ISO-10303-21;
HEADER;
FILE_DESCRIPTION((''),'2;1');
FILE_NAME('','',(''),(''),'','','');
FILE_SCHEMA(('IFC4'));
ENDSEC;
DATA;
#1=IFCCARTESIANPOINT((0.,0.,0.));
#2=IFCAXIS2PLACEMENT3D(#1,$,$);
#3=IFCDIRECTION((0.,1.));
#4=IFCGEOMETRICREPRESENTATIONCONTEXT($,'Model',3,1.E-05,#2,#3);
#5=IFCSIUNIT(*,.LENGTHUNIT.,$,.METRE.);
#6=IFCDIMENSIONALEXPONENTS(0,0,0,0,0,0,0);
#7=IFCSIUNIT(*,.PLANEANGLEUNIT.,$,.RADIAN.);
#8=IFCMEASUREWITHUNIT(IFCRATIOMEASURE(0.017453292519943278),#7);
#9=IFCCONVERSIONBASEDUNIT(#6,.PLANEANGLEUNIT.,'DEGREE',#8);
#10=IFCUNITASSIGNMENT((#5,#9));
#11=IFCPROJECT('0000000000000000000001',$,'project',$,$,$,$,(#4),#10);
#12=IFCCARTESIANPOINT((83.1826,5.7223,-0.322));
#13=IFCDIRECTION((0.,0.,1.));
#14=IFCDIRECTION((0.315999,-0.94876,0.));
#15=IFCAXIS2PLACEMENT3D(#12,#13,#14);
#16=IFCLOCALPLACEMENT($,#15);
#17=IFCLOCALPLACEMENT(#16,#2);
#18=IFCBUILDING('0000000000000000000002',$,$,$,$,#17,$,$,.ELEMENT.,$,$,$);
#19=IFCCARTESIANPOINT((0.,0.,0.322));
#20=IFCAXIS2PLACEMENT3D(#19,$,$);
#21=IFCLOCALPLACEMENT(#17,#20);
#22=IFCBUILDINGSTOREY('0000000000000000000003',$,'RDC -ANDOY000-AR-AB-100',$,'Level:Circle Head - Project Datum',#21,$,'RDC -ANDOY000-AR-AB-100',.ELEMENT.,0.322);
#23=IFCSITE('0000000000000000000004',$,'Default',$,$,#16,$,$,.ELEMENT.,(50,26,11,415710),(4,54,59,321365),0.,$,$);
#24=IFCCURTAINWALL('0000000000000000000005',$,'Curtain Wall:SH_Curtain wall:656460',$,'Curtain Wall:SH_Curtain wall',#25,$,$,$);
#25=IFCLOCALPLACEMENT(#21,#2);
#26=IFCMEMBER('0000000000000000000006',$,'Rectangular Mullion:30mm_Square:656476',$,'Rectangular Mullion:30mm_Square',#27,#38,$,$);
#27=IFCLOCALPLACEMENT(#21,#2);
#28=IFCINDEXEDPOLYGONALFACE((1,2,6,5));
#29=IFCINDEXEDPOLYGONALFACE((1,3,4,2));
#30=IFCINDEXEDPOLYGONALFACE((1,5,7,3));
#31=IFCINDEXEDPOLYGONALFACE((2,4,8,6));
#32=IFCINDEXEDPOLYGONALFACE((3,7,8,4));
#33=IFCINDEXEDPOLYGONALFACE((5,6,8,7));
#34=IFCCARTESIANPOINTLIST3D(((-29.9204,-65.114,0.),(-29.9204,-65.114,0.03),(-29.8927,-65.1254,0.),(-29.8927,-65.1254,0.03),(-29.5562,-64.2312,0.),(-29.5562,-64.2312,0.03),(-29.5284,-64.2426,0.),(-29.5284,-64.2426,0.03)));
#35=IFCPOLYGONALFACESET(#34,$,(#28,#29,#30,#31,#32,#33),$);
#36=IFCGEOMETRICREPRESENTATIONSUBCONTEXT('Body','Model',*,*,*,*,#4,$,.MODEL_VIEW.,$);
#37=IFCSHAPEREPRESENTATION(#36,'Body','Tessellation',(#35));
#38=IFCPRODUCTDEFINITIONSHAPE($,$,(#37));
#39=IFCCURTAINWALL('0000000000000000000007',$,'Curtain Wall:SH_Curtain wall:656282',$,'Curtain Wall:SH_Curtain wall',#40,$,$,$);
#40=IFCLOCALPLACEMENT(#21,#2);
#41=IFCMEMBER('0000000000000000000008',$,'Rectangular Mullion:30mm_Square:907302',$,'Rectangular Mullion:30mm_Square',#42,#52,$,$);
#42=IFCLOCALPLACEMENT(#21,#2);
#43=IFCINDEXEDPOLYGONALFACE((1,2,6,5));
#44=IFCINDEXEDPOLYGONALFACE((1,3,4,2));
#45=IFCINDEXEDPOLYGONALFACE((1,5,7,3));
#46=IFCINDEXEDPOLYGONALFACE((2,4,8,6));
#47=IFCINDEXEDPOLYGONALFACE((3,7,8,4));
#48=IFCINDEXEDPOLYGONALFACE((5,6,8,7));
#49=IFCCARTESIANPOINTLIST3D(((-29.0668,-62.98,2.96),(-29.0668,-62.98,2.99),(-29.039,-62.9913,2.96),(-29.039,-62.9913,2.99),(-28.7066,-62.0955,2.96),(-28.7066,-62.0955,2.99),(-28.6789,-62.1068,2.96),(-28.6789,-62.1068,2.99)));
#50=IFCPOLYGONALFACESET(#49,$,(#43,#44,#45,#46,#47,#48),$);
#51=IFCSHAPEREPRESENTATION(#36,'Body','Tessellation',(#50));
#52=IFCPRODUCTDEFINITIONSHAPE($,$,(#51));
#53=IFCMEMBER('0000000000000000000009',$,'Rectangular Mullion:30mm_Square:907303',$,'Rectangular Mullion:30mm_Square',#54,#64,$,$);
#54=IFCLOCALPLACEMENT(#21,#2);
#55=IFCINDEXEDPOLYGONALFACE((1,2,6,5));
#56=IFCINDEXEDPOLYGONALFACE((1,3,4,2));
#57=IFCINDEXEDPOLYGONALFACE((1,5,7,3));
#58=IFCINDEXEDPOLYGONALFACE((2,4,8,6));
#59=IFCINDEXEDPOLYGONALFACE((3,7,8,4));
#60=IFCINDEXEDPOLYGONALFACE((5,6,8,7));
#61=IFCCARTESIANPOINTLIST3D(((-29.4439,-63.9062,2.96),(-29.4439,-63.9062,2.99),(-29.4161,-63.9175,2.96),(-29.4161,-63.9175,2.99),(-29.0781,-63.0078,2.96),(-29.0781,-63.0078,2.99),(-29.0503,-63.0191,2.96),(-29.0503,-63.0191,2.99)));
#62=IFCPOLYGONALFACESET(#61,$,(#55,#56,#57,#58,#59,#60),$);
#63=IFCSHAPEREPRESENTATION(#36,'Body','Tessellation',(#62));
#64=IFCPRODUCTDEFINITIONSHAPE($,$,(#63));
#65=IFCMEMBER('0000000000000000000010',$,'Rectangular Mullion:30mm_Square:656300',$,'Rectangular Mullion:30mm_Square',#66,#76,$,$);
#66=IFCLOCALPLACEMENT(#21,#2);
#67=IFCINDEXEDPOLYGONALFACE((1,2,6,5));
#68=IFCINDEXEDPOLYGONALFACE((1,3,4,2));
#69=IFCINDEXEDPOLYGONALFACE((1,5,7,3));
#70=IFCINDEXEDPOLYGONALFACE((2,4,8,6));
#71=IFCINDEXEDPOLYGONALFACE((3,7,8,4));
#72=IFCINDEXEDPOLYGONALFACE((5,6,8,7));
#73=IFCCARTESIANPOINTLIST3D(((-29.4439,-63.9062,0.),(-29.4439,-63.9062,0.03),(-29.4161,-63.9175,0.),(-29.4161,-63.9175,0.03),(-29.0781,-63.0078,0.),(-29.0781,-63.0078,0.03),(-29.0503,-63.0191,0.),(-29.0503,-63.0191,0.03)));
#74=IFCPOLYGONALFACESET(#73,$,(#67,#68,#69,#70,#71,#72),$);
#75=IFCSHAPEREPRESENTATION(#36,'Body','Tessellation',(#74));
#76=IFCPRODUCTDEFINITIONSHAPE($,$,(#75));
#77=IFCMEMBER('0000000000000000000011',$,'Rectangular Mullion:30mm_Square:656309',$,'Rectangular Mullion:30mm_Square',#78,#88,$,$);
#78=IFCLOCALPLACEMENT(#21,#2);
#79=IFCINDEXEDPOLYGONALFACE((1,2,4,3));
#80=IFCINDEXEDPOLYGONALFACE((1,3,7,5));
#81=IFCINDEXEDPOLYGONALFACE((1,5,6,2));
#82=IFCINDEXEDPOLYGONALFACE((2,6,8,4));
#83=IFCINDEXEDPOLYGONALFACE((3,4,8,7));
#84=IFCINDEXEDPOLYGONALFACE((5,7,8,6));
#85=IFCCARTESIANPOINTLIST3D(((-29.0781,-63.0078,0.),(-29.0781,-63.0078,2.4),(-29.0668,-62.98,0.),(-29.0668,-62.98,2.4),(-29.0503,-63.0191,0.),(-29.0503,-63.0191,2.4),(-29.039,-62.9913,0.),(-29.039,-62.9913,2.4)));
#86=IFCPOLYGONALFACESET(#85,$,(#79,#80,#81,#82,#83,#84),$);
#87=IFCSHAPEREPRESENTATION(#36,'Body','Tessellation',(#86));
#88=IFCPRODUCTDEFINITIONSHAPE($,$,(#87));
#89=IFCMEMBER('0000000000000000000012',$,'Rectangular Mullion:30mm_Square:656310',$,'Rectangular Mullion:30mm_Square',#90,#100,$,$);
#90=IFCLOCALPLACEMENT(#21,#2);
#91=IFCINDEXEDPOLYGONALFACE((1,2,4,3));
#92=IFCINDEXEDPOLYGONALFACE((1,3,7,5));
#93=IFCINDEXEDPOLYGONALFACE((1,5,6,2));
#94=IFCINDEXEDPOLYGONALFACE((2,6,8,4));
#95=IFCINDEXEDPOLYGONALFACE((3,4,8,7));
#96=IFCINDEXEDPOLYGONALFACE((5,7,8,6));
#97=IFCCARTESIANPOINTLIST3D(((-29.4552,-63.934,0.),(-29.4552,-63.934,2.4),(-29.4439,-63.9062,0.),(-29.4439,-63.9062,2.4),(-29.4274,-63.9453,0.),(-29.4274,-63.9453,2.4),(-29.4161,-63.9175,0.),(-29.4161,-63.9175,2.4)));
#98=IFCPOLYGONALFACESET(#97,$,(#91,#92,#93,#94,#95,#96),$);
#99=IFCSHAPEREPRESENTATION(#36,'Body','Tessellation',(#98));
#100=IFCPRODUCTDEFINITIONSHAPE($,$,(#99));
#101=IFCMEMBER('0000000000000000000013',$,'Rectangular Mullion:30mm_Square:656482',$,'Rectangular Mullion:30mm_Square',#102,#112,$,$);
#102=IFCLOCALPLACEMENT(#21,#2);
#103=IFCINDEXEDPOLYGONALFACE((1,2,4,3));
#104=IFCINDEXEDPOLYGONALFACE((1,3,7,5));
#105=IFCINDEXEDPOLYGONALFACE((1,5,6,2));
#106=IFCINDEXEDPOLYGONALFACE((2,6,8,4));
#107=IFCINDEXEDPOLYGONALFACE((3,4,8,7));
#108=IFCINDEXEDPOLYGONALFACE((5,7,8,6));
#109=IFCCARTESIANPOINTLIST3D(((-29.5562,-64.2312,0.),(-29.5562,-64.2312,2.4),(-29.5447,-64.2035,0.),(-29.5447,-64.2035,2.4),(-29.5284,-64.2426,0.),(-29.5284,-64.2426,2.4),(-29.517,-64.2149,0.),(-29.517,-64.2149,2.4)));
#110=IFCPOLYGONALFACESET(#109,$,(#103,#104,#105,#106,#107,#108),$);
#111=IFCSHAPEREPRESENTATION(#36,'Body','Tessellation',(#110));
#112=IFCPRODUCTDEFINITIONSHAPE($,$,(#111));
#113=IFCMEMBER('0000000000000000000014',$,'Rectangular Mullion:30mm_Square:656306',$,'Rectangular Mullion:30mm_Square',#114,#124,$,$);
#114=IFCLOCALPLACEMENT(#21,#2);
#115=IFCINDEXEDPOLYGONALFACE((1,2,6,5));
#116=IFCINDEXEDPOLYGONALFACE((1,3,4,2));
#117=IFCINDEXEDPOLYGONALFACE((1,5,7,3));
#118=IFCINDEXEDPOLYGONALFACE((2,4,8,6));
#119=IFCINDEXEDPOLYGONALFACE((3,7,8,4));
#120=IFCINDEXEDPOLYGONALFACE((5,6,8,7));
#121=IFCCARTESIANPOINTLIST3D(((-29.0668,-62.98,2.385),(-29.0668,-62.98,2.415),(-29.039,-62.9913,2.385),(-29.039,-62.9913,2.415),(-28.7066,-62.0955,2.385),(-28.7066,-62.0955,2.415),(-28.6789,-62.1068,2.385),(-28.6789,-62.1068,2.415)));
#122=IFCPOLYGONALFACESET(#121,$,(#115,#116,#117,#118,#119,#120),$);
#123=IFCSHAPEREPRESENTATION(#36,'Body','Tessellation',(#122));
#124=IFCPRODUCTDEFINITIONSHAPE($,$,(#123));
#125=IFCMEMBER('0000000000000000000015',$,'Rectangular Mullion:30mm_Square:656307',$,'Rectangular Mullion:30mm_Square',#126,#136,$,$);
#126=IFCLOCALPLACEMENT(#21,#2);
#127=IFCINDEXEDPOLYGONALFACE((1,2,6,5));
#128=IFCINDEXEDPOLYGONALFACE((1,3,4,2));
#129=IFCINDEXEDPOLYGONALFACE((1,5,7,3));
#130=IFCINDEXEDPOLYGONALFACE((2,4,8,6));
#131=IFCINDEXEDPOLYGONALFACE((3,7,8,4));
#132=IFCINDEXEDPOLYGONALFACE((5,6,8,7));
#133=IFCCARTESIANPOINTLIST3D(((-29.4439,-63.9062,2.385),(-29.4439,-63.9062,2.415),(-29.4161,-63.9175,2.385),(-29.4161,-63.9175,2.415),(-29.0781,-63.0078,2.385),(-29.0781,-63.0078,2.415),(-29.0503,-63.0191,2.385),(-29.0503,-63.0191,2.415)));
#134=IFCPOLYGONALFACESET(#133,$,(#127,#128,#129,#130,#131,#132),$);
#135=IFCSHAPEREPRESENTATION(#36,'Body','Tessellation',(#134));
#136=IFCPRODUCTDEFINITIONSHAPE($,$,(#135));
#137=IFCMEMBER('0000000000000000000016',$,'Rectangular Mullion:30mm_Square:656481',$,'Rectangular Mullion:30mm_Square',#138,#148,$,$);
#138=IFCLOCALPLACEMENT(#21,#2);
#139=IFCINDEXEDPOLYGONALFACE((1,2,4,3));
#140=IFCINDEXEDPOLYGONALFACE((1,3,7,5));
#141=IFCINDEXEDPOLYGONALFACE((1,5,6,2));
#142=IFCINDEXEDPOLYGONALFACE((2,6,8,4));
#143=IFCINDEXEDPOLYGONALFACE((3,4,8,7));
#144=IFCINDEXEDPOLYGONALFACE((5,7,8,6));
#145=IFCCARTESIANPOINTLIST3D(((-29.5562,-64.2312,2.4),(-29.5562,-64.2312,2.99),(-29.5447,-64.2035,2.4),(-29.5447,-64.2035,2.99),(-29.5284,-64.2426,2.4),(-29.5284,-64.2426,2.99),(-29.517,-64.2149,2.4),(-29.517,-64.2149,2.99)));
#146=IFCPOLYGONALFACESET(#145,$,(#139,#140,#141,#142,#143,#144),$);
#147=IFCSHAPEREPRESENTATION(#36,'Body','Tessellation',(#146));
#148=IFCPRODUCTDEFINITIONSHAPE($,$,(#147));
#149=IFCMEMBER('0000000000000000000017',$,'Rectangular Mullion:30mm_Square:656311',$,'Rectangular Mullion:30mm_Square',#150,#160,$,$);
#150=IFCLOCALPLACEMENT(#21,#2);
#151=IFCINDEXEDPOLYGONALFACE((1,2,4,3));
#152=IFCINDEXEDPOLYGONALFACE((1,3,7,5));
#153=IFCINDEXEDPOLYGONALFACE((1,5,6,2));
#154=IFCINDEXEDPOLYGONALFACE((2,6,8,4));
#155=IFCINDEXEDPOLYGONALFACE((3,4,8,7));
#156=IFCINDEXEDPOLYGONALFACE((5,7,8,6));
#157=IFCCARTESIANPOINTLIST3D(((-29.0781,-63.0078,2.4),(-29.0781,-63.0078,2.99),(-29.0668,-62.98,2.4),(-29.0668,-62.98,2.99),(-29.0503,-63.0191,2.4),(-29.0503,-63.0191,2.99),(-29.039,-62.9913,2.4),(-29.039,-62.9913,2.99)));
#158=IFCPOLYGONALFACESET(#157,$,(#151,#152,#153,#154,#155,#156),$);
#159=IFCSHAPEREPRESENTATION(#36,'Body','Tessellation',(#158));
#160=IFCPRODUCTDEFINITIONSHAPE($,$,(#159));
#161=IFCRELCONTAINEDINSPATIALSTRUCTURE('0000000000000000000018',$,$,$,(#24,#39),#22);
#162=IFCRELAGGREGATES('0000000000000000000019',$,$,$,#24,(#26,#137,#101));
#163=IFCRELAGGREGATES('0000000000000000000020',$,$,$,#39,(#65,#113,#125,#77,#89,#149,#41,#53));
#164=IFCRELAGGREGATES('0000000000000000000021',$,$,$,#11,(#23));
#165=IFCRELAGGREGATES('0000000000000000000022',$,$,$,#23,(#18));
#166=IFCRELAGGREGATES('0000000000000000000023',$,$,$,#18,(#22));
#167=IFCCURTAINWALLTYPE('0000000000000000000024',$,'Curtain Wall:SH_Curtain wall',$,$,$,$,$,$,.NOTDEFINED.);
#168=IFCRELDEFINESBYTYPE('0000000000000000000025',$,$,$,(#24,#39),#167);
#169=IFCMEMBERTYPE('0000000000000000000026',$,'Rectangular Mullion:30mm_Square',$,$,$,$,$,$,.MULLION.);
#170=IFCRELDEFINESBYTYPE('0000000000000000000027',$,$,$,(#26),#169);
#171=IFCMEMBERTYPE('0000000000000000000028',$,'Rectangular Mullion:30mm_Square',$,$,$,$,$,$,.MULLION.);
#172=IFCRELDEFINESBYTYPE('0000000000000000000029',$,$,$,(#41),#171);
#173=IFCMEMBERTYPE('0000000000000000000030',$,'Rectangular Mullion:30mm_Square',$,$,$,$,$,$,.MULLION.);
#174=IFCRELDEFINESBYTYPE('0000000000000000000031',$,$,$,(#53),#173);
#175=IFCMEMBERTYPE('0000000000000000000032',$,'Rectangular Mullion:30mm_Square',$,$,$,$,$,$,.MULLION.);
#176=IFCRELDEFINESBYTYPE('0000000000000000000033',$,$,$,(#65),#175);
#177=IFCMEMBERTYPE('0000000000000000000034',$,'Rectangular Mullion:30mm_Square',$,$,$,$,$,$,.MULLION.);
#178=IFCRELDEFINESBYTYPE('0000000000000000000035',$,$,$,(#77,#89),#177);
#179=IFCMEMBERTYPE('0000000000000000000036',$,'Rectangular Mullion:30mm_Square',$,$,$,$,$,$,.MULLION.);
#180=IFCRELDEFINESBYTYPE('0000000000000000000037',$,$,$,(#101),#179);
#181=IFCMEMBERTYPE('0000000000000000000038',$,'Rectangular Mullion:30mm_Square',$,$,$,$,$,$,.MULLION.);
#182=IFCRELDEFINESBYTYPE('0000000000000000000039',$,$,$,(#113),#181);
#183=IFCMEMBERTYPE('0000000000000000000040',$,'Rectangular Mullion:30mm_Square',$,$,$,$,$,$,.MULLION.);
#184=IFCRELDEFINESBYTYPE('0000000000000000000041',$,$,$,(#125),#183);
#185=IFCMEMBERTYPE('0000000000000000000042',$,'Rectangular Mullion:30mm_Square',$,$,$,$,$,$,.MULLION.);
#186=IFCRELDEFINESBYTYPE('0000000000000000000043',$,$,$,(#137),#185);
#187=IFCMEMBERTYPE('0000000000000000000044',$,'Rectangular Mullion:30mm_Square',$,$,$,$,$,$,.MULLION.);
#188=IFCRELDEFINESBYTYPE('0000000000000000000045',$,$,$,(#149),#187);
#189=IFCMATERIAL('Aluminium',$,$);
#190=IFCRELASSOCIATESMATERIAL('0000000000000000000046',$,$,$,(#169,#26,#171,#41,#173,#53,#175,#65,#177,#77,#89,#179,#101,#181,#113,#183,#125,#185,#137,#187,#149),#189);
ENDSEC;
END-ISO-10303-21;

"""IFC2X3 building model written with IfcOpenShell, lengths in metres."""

from ifc_helpers import new_model, entity, si_unit, converted_unit, direction, frame, origin, origin_2d_with_axis, place, context, subcontext, project, spatial, rectangle, extrude, source, transform, mapped, material, type_object, type_shapes, element, aggregate, save


model = new_model("IFC2X3")

# Units and contexts
model_context = context("Model", 3, precision=1e-05, world=origin(), true_north=direction((0.0, 1.0)))
body_context = subcontext(model_context, "Body", "Model", "MODEL_VIEW")
ifc_project = project(units=[si_unit("LENGTHUNIT", "METRE"), converted_unit("PLANEANGLEUNIT", "DEGREE", entity("IfcRatioMeasure", 0.017453292519943278), si_unit("PLANEANGLEUNIT", "RADIAN"), dimensions=[0, 0, 0, 0, 0, 0, 0])], contexts=[model_context])

# Site, building, storey
site_placement = place(None, frame((83.1826, 5.7223, -0.322), z_axis=(0.0, 0.0, 1.0), x_axis=(0.315999, -0.94876, 0.0)))
site = spatial("IfcSite", under=ifc_project, at=site_placement, Name="Default", CompositionType="ELEMENT", RefLatitude=(50, 26, 11, 415710), RefLongitude=(4, 54, 59, 321365), RefElevation=0.0)
building_placement = place(site_placement, origin())
building = spatial("IfcBuilding", under=site, at=building_placement, CompositionType="ELEMENT")
storey_placement = place(building_placement, frame((0.0, 0.0, 0.322)))
storey = spatial("IfcBuildingStorey", under=building, at=storey_placement, Name="RDC -ANDOY000-AR-AB-100", ObjectType="Level:Circle Head - Project Datum", LongName="RDC -ANDOY000-AR-AB-100", CompositionType="ELEMENT", Elevation=0.322)

# Curtain wall, member
curtain_wall_type = type_object("IfcCurtainWallType", Name="Curtain Wall:SH_Curtain wall", PredefinedType="NOTDEFINED")
curtain_wall_1_placement = place(storey_placement, frame((0.0, 0.0, -0.322)))
curtain_wall_1 = element("IfcCurtainWall", 1, at=curtain_wall_1_placement, inside=storey, type_object=curtain_wall_type, Name="Curtain Wall:SH_Curtain wall:656460", ObjectType="Curtain Wall:SH_Curtain wall")
ifc_material_1 = material(Name="Aluminium")
member_type_1 = type_object("IfcMemberType", Name="Rectangular Mullion:30mm_Square", PredefinedType="MULLION", material=ifc_material_1)
shared_shape_1 = source(origin(), body_context, "Body", "SweptSolid", [
    extrude(rectangle(XDim=0.03, YDim=0.03, at=origin_2d_with_axis()), frame((-0.015, 0.0, -0.955), z_axis=(0.0, 0.0, 1.0), x_axis=(0.0, -1.0, 0.0)), (0.0, 0.0, 1.0), 0.955),
])
type_shapes(member_type_1, [shared_shape_1])
member_1_placement = place(curtain_wall_1_placement, frame((-29.5423, -64.2369, 0.322), z_axis=(0.381413, 0.924405, 0.0), x_axis=(0.0, 0.0, -1.0)))
member_1 = element("IfcMember", 2, at=member_1_placement, type_object=member_type_1, material=ifc_material_1, Name="Rectangular Mullion:30mm_Square:656476", ObjectType="Rectangular Mullion:30mm_Square", context=body_context, shape_type="MappedRepresentation", body=[
    mapped(shared_shape_1, transform((0.0, 0.0, 0.0), scale=1.0)),
])

# Curtain wall, members
curtain_wall_2_placement = place(storey_placement, frame((0.0, 0.0, -0.322)))
curtain_wall_2 = element("IfcCurtainWall", 3, at=curtain_wall_2_placement, inside=storey, type_object=curtain_wall_type, Name="Curtain Wall:SH_Curtain wall:656282", ObjectType="Curtain Wall:SH_Curtain wall")
member_type_2 = type_object("IfcMemberType", Name="Rectangular Mullion:30mm_Square", PredefinedType="MULLION", material=ifc_material_1)
shared_shape_2 = source(origin(), body_context, "Body", "SweptSolid", [
    extrude(rectangle(XDim=0.03, YDim=0.03, at=origin_2d_with_axis()), frame((-0.015, 0.0, -0.955), z_axis=(0.0, 0.0, 1.0), x_axis=(0.0, -1.0, 0.0)), (0.0, 0.0, 1.0), 0.955),
])
type_shapes(member_type_2, [shared_shape_2])
member_2_placement = place(curtain_wall_2_placement, frame((-29.0529, -62.9857, 3.312), z_axis=(-0.377092, -0.926176, 0.0), x_axis=(0.0, 0.0, 1.0)))
member_2 = element("IfcMember", 4, at=member_2_placement, type_object=member_type_2, material=ifc_material_1, Name="Rectangular Mullion:30mm_Square:907302", ObjectType="Rectangular Mullion:30mm_Square", context=body_context, shape_type="MappedRepresentation", body=[
    mapped(shared_shape_2, transform((0.0, 0.0, 0.0), scale=1.0)),
])
member_type_3 = type_object("IfcMemberType", Name="Rectangular Mullion:30mm_Square", PredefinedType="MULLION", material=ifc_material_1)
shared_shape_3 = source(origin(), body_context, "Body", "SweptSolid", [
    extrude(rectangle(XDim=0.03, YDim=0.03, at=origin_2d_with_axis()), frame((-0.015, 0.0, -0.97), z_axis=(0.0, 0.0, 1.0), x_axis=(0.0, -1.0, 0.0)), (0.0, 0.0, 1.0), 0.97),
])
type_shapes(member_type_3, [shared_shape_3])
member_3_placement = place(curtain_wall_2_placement, frame((-29.43, -63.9119, 3.312), z_axis=(-0.377092, -0.926176, 0.0), x_axis=(0.0, 0.0, 1.0)))
member_3 = element("IfcMember", 5, at=member_3_placement, type_object=member_type_3, material=ifc_material_1, Name="Rectangular Mullion:30mm_Square:907303", ObjectType="Rectangular Mullion:30mm_Square", context=body_context, shape_type="MappedRepresentation", body=[
    mapped(shared_shape_3, transform((0.0, 0.0, 0.0), scale=1.0)),
])
member_type_4 = type_object("IfcMemberType", Name="Rectangular Mullion:30mm_Square", PredefinedType="MULLION", material=ifc_material_1)
shared_shape_4 = source(origin(), body_context, "Body", "SweptSolid", [
    extrude(rectangle(XDim=0.03, YDim=0.03, at=origin_2d_with_axis()), frame((-0.015, 0.0, -0.97), z_axis=(0.0, 0.0, 1.0), x_axis=(0.0, -1.0, 0.0)), (0.0, 0.0, 1.0), 0.97),
])
type_shapes(member_type_4, [shared_shape_4])
member_4_placement = place(curtain_wall_2_placement, frame((-29.0642, -63.0135, 0.322), z_axis=(0.377092, 0.926176, 0.0), x_axis=(0.0, 0.0, -1.0)))
member_4 = element("IfcMember", 6, at=member_4_placement, type_object=member_type_4, material=ifc_material_1, Name="Rectangular Mullion:30mm_Square:656300", ObjectType="Rectangular Mullion:30mm_Square", context=body_context, shape_type="MappedRepresentation", body=[
    mapped(shared_shape_4, transform((0.0, 0.0, 0.0), scale=1.0)),
])
member_type_5 = type_object("IfcMemberType", Name="Rectangular Mullion:30mm_Square", PredefinedType="MULLION", material=ifc_material_1)
shared_shape_5 = source(origin(), body_context, "Body", "SweptSolid", [
    extrude(rectangle(XDim=0.03, YDim=0.03, at=origin_2d_with_axis()), frame((0.0, 0.0, -2.4), z_axis=(0.0, 0.0, 1.0), x_axis=(0.0, -1.0, 0.0)), (0.0, 0.0, 1.0), 2.4),
])
type_shapes(member_type_5, [shared_shape_5])
member_5_placement = place(curtain_wall_2_placement, frame((-29.0585, -62.9996, 0.322), z_axis=(0.0, 0.0, -1.0), x_axis=(-0.377092, -0.926176, 0.0)))
member_5 = element("IfcMember", 7, at=member_5_placement, type_object=member_type_5, material=ifc_material_1, Name="Rectangular Mullion:30mm_Square:656309", ObjectType="Rectangular Mullion:30mm_Square", context=body_context, shape_type="MappedRepresentation", body=[
    mapped(shared_shape_5, transform((0.0, 0.0, 0.0), scale=1.0)),
])
member_6_placement = place(curtain_wall_2_placement, frame((-29.4356, -63.9258, 0.322), z_axis=(0.0, 0.0, -1.0), x_axis=(-0.377092, -0.926176, 0.0)))
member_6 = element("IfcMember", 8, at=member_6_placement, type_object=member_type_5, material=ifc_material_1, Name="Rectangular Mullion:30mm_Square:656310", ObjectType="Rectangular Mullion:30mm_Square", context=body_context, shape_type="MappedRepresentation", body=[
    mapped(shared_shape_5, transform((0.0, 0.0, 0.0), scale=1.0)),
])

# Members
member_type_6 = type_object("IfcMemberType", Name="Rectangular Mullion:30mm_Square", PredefinedType="MULLION", material=ifc_material_1)
shared_shape_6 = source(origin(), body_context, "Body", "SweptSolid", [
    extrude(rectangle(XDim=0.03, YDim=0.03, at=origin_2d_with_axis()), frame((-0.015, 0.0, -2.4), z_axis=(0.0, 0.0, 1.0), x_axis=(0.0, -1.0, 0.0)), (0.0, 0.0, 1.0), 2.4),
])
type_shapes(member_type_6, [shared_shape_6])
member_7_placement = place(curtain_wall_1_placement, frame((-29.5309, -64.2092, 2.722), z_axis=(0.0, 0.0, 1.0), x_axis=(0.381413, 0.924405, 0.0)))
member_7 = element("IfcMember", 9, at=member_7_placement, type_object=member_type_6, material=ifc_material_1, Name="Rectangular Mullion:30mm_Square:656482", ObjectType="Rectangular Mullion:30mm_Square", context=body_context, shape_type="MappedRepresentation", body=[
    mapped(shared_shape_6, transform((0.0, 0.0, 0.0), scale=1.0)),
])
member_type_7 = type_object("IfcMemberType", Name="Rectangular Mullion:30mm_Square", PredefinedType="MULLION", material=ifc_material_1)
shared_shape_7 = source(origin(), body_context, "Body", "SweptSolid", [
    extrude(rectangle(XDim=0.03, YDim=0.03, at=origin_2d_with_axis()), frame((0.0, 0.0, -0.955), z_axis=(0.0, 0.0, 1.0), x_axis=(0.0, -1.0, 0.0)), (0.0, 0.0, 1.0), 0.955),
])
type_shapes(member_type_7, [shared_shape_7])
member_8_placement = place(curtain_wall_2_placement, frame((-29.0529, -62.9857, 2.722), z_axis=(-0.377092, -0.926176, 0.0), x_axis=(0.0, 0.0, 1.0)))
member_8 = element("IfcMember", 10, at=member_8_placement, type_object=member_type_7, material=ifc_material_1, Name="Rectangular Mullion:30mm_Square:656306", ObjectType="Rectangular Mullion:30mm_Square", context=body_context, shape_type="MappedRepresentation", body=[
    mapped(shared_shape_7, transform((0.0, 0.0, 0.0), scale=1.0)),
])
member_type_8 = type_object("IfcMemberType", Name="Rectangular Mullion:30mm_Square", PredefinedType="MULLION", material=ifc_material_1)
shared_shape_8 = source(origin(), body_context, "Body", "SweptSolid", [
    extrude(rectangle(XDim=0.03, YDim=0.03, at=origin_2d_with_axis()), frame((0.0, 0.0, -0.97), z_axis=(0.0, 0.0, 1.0), x_axis=(0.0, -1.0, 0.0)), (0.0, 0.0, 1.0), 0.97),
])
type_shapes(member_type_8, [shared_shape_8])
member_9_placement = place(curtain_wall_2_placement, frame((-29.43, -63.9119, 2.722), z_axis=(-0.377092, -0.926176, 0.0), x_axis=(0.0, 0.0, 1.0)))
member_9 = element("IfcMember", 11, at=member_9_placement, type_object=member_type_8, material=ifc_material_1, Name="Rectangular Mullion:30mm_Square:656307", ObjectType="Rectangular Mullion:30mm_Square", context=body_context, shape_type="MappedRepresentation", body=[
    mapped(shared_shape_8, transform((0.0, 0.0, 0.0), scale=1.0)),
])
member_type_9 = type_object("IfcMemberType", Name="Rectangular Mullion:30mm_Square", PredefinedType="MULLION", material=ifc_material_1)
shared_shape_9 = source(origin(), body_context, "Body", "SweptSolid", [
    extrude(rectangle(XDim=0.03, YDim=0.03, at=origin_2d_with_axis()), frame((-0.015, 0.0, -0.59), z_axis=(0.0, 0.0, 1.0), x_axis=(0.0, -1.0, 0.0)), (0.0, 0.0, 1.0), 0.59),
])
type_shapes(member_type_9, [shared_shape_9])
member_10_placement = place(curtain_wall_1_placement, frame((-29.5309, -64.2092, 3.312), z_axis=(0.0, 0.0, 1.0), x_axis=(0.381413, 0.924405, 0.0)))
member_10 = element("IfcMember", 12, at=member_10_placement, type_object=member_type_9, material=ifc_material_1, Name="Rectangular Mullion:30mm_Square:656481", ObjectType="Rectangular Mullion:30mm_Square", context=body_context, shape_type="MappedRepresentation", body=[
    mapped(shared_shape_9, transform((0.0, 0.0, 0.0), scale=1.0)),
])
aggregate(curtain_wall_1, [member_1, member_10, member_7])
member_type_10 = type_object("IfcMemberType", Name="Rectangular Mullion:30mm_Square", PredefinedType="MULLION", material=ifc_material_1)
shared_shape_10 = source(origin(), body_context, "Body", "SweptSolid", [
    extrude(rectangle(XDim=0.03, YDim=0.03, at=origin_2d_with_axis()), frame((0.0, 0.0, -0.59), z_axis=(0.0, 0.0, 1.0), x_axis=(0.0, -1.0, 0.0)), (0.0, 0.0, 1.0), 0.59),
])
type_shapes(member_type_10, [shared_shape_10])
member_11_placement = place(curtain_wall_2_placement, frame((-29.0585, -62.9996, 2.722), z_axis=(0.0, 0.0, -1.0), x_axis=(-0.377092, -0.926176, 0.0)))
member_11 = element("IfcMember", 13, at=member_11_placement, type_object=member_type_10, material=ifc_material_1, Name="Rectangular Mullion:30mm_Square:656311", ObjectType="Rectangular Mullion:30mm_Square", context=body_context, shape_type="MappedRepresentation", body=[
    mapped(shared_shape_10, transform((0.0, 0.0, 0.0), scale=1.0)),
])

aggregate(curtain_wall_2, [member_4, member_8, member_9, member_5, member_6, member_11, member_2, member_3])

save(model, "model.ifc")
